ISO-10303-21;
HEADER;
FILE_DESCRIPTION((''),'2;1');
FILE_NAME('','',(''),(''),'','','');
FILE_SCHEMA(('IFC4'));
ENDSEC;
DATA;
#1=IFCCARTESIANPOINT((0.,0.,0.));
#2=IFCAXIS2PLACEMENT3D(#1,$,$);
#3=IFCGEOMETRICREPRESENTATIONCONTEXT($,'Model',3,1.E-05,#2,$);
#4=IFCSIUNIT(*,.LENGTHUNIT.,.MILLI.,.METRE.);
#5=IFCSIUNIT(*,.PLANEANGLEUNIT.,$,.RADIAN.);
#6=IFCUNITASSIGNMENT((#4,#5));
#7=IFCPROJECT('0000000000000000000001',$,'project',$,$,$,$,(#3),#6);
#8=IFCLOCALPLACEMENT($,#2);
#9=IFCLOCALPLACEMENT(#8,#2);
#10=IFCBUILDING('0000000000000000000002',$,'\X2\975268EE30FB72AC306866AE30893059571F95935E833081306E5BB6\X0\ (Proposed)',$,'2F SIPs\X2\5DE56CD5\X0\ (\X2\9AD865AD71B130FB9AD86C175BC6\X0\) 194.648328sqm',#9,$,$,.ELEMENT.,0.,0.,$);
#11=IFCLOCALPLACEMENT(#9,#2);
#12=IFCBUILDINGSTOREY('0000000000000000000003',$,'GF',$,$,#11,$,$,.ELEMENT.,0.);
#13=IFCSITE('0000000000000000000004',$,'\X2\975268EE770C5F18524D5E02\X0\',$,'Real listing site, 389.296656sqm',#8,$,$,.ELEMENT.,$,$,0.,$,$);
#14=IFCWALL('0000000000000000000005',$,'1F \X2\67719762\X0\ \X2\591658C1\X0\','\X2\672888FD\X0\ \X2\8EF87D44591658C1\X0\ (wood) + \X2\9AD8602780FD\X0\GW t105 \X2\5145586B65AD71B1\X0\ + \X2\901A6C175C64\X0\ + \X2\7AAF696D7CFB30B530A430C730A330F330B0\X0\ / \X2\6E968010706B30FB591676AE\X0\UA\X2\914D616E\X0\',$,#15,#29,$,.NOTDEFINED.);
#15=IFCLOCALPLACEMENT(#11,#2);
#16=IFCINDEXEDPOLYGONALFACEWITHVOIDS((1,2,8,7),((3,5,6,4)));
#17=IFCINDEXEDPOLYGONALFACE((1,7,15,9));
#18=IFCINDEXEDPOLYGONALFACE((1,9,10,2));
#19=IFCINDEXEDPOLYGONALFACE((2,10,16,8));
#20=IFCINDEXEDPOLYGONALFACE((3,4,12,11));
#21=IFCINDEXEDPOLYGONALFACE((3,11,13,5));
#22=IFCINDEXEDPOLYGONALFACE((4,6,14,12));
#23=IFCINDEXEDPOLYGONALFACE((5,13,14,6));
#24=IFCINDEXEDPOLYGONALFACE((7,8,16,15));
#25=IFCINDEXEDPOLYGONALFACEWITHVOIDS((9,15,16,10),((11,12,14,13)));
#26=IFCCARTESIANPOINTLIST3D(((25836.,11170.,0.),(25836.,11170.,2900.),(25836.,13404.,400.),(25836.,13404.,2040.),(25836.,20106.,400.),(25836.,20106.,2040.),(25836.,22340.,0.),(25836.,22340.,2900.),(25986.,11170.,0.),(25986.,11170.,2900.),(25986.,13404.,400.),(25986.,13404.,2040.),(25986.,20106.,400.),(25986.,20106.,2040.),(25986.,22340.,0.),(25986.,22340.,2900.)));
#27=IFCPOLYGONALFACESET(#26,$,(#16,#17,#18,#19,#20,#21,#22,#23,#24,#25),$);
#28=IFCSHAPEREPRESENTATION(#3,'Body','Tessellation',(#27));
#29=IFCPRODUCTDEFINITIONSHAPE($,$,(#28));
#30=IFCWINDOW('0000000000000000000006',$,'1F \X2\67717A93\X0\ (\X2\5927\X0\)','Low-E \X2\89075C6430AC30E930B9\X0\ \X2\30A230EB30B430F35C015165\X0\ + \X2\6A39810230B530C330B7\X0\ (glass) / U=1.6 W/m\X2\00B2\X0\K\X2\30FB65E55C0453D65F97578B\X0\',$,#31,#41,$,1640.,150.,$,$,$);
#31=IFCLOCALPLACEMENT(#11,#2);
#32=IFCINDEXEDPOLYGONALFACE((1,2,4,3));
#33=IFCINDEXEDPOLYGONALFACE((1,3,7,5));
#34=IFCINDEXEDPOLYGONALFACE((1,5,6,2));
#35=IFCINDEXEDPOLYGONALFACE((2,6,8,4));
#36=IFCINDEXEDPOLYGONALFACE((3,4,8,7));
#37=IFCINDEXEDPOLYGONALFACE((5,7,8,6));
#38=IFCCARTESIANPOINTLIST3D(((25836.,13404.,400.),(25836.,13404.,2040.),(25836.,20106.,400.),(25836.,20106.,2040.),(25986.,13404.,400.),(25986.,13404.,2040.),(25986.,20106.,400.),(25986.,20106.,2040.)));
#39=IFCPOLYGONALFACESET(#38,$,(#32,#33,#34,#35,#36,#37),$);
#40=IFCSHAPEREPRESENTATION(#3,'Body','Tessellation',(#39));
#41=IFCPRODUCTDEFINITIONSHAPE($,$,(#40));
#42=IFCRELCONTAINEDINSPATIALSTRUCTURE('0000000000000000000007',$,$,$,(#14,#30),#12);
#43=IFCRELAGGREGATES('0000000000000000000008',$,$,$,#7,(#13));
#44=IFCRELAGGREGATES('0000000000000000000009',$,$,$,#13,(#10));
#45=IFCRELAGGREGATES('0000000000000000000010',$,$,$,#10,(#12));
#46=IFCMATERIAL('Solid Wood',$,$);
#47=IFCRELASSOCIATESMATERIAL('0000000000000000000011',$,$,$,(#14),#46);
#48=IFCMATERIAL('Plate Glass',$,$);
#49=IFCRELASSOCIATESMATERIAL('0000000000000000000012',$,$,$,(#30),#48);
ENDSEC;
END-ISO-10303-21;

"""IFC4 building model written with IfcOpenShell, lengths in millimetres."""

from ifc_helpers import new_model, si_unit, frame, frame_2d, origin, place, context, project, spatial, rectangle, extrude, material, element, fill, save


model = new_model("IFC4")

# Units and contexts
model_context = context("Model", 3, precision=1e-05, world=origin())
ifc_project = project(units=[si_unit("LENGTHUNIT", "METRE", prefix="MILLI"), si_unit("PLANEANGLEUNIT", "RADIAN")], contexts=[model_context])

# Site, building, storey
site_placement = place(None, origin())
site = spatial("IfcSite", under=ifc_project, at=site_placement, Name="青森県弘前市", ObjectType="Real listing site, 389.296656sqm", CompositionType="ELEMENT", RefElevation=0.0)
building_placement = place(site_placement, origin())
building = spatial("IfcBuilding", under=site, at=building_placement, Name="青森・犬と暮らす土間広めの家 (Proposed)", ObjectType="2F SIPs工法 (高断熱・高気密) 194.648328sqm", CompositionType="ELEMENT", ElevationOfRefHeight=0.0, ElevationOfTerrain=0.0)
storey_placement = place(building_placement, origin())
storey = spatial("IfcBuildingStorey", under=building, at=storey_placement, Name="GF", CompositionType="ELEMENT", Elevation=0.0)

# Wall, opening, window
ifc_material_1 = material(Name="Solid Wood")
wall_1_placement = place(storey_placement, frame((12918.0, 5585.0, 0.0)))
wall_1 = element("IfcWall", 1, at=wall_1_placement, inside=storey, material=ifc_material_1, Name="1F 東面 外壁", Description="木製 軸組外壁 (wood) + 高性能GW t105 充填断熱 + 通気層 + 窯業系サイディング / 準耐火・外皮UA配慮", PredefinedType="NOTDEFINED", context=model_context, shape_type="SweptSolid", body=[
    extrude(rectangle(XDim=150.0, YDim=11170.0, at=frame_2d((75.0, 5585.0))), frame((12918.0, 5585.0, 0.0)), (0.0, 0.0, 1.0), 2900.0),
])
opening_1_placement = place(storey_placement, frame((12918.0, 6702.0, 200.0)))
opening_1 = element("IfcOpeningElement", 2, at=opening_1_placement, cuts=wall_1, PredefinedType="NOTDEFINED", context=model_context, shape_type="SweptSolid", body=[
    extrude(rectangle(XDim=150.0, YDim=6702.0, at=frame_2d((75.0, 3351.0))), frame((12918.0, 6702.0, 200.0)), (0.0, 0.0, 1.0), 1640.0),
])
ifc_material_2 = material(Name="Plate Glass")
window_1_placement = place(storey_placement, frame((12918.0, 6702.0, 200.0)))
window_1 = element("IfcWindow", 3, at=window_1_placement, inside=storey, material=ifc_material_2, Name="1F 東窓 (大)", Description="Low-E 複層ガラス アルゴン封入 + 樹脂サッシ (glass) / U=1.6 W/m²K・日射取得型", OverallHeight=1640.0, OverallWidth=150.0, context=model_context, shape_type="SweptSolid", body=[
    extrude(rectangle(XDim=150.0, YDim=6702.0, at=frame_2d((75.0, 3351.0))), frame((12918.0, 6702.0, 200.0)), (0.0, 0.0, 1.0), 1640.0),
])
fill(opening_1, window_1)

save(model, "model.ifc")
